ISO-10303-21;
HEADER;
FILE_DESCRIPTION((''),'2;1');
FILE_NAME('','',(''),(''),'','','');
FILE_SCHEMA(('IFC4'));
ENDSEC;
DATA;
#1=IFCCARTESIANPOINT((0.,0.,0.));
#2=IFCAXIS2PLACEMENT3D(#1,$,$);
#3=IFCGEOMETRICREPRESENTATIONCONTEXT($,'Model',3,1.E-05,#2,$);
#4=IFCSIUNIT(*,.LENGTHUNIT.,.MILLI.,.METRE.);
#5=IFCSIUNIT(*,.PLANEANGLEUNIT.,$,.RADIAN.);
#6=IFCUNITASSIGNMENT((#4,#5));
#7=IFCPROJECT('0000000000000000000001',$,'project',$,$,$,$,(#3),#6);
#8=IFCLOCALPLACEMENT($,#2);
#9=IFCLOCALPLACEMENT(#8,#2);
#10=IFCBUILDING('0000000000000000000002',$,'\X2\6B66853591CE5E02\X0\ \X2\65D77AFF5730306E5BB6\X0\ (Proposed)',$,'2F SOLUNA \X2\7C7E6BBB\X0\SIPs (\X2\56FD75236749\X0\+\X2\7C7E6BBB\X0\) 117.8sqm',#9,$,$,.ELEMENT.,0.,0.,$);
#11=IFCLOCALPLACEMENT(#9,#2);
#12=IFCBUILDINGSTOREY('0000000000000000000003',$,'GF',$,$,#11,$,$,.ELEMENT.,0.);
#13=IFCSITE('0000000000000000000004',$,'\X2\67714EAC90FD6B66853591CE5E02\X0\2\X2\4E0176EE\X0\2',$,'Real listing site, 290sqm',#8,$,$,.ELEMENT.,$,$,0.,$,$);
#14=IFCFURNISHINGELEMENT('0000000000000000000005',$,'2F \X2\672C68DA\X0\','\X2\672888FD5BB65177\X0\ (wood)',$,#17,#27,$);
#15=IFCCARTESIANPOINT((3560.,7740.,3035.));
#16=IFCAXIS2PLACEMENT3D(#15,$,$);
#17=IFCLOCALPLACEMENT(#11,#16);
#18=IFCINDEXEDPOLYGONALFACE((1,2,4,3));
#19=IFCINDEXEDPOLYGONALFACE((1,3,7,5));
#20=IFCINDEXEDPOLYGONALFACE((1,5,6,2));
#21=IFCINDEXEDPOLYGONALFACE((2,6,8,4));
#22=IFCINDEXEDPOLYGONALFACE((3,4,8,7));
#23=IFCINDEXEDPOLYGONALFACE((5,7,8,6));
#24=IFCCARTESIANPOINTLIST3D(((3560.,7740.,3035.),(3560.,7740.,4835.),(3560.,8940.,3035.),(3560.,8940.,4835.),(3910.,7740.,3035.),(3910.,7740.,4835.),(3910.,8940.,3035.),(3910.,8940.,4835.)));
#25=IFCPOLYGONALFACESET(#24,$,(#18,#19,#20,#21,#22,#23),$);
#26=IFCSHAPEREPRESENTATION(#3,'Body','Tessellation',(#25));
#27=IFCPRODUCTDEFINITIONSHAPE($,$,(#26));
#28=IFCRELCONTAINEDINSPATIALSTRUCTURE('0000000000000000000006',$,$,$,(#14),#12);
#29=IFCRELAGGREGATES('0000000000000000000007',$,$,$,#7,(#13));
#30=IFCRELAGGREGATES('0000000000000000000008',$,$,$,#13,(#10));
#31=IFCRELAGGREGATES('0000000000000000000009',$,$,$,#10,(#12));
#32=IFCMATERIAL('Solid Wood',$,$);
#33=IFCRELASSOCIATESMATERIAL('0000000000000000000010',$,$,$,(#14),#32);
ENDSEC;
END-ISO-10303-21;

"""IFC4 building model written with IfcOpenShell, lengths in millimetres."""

from ifc_helpers import new_model, si_unit, frame, frame_2d, origin, place, context, project, spatial, rectangle, extrude, material, element, save


model = new_model("IFC4")

# Units and contexts
model_context = context("Model", 3, precision=1e-05, world=origin())
ifc_project = project(units=[si_unit("LENGTHUNIT", "METRE", prefix="MILLI"), si_unit("PLANEANGLEUNIT", "RADIAN")], contexts=[model_context])

# Site, building, storey
site_placement = place(None, origin())
site = spatial("IfcSite", under=ifc_project, at=site_placement, Name="東京都武蔵野市2丁目2", ObjectType="Real listing site, 290sqm", CompositionType="ELEMENT", RefElevation=0.0)
building_placement = place(site_placement, origin())
building = spatial("IfcBuilding", under=site, at=building_placement, Name="武蔵野市 旗竿地の家 (Proposed)", ObjectType="2F SOLUNA 籾殻SIPs (国産杉+籾殻) 117.8sqm", CompositionType="ELEMENT", ElevationOfRefHeight=0.0, ElevationOfTerrain=0.0)
storey_placement = place(building_placement, origin())
storey = spatial("IfcBuildingStorey", under=building, at=storey_placement, Name="GF", CompositionType="ELEMENT", Elevation=0.0)

# Shared definitions
ifc_material_1 = material(Name="Solid Wood")

# Furnishing element
furnishing_placement = place(storey_placement, frame((3560.0, 7740.0, 3035.0)))
element("IfcFurnishingElement", 1, at=furnishing_placement, inside=storey, material=ifc_material_1, Name="2F 本棚", Description="木製家具 (wood)", context=model_context, shape_type="SweptSolid", body=[
    extrude(rectangle(XDim=350.0, YDim=1200.0, at=frame_2d((175.0, 600.0))), frame((3560.0, 7740.0, 3035.0)), (0.0, 0.0, 1.0), 1800.0),
])

save(model, "model.ifc")
